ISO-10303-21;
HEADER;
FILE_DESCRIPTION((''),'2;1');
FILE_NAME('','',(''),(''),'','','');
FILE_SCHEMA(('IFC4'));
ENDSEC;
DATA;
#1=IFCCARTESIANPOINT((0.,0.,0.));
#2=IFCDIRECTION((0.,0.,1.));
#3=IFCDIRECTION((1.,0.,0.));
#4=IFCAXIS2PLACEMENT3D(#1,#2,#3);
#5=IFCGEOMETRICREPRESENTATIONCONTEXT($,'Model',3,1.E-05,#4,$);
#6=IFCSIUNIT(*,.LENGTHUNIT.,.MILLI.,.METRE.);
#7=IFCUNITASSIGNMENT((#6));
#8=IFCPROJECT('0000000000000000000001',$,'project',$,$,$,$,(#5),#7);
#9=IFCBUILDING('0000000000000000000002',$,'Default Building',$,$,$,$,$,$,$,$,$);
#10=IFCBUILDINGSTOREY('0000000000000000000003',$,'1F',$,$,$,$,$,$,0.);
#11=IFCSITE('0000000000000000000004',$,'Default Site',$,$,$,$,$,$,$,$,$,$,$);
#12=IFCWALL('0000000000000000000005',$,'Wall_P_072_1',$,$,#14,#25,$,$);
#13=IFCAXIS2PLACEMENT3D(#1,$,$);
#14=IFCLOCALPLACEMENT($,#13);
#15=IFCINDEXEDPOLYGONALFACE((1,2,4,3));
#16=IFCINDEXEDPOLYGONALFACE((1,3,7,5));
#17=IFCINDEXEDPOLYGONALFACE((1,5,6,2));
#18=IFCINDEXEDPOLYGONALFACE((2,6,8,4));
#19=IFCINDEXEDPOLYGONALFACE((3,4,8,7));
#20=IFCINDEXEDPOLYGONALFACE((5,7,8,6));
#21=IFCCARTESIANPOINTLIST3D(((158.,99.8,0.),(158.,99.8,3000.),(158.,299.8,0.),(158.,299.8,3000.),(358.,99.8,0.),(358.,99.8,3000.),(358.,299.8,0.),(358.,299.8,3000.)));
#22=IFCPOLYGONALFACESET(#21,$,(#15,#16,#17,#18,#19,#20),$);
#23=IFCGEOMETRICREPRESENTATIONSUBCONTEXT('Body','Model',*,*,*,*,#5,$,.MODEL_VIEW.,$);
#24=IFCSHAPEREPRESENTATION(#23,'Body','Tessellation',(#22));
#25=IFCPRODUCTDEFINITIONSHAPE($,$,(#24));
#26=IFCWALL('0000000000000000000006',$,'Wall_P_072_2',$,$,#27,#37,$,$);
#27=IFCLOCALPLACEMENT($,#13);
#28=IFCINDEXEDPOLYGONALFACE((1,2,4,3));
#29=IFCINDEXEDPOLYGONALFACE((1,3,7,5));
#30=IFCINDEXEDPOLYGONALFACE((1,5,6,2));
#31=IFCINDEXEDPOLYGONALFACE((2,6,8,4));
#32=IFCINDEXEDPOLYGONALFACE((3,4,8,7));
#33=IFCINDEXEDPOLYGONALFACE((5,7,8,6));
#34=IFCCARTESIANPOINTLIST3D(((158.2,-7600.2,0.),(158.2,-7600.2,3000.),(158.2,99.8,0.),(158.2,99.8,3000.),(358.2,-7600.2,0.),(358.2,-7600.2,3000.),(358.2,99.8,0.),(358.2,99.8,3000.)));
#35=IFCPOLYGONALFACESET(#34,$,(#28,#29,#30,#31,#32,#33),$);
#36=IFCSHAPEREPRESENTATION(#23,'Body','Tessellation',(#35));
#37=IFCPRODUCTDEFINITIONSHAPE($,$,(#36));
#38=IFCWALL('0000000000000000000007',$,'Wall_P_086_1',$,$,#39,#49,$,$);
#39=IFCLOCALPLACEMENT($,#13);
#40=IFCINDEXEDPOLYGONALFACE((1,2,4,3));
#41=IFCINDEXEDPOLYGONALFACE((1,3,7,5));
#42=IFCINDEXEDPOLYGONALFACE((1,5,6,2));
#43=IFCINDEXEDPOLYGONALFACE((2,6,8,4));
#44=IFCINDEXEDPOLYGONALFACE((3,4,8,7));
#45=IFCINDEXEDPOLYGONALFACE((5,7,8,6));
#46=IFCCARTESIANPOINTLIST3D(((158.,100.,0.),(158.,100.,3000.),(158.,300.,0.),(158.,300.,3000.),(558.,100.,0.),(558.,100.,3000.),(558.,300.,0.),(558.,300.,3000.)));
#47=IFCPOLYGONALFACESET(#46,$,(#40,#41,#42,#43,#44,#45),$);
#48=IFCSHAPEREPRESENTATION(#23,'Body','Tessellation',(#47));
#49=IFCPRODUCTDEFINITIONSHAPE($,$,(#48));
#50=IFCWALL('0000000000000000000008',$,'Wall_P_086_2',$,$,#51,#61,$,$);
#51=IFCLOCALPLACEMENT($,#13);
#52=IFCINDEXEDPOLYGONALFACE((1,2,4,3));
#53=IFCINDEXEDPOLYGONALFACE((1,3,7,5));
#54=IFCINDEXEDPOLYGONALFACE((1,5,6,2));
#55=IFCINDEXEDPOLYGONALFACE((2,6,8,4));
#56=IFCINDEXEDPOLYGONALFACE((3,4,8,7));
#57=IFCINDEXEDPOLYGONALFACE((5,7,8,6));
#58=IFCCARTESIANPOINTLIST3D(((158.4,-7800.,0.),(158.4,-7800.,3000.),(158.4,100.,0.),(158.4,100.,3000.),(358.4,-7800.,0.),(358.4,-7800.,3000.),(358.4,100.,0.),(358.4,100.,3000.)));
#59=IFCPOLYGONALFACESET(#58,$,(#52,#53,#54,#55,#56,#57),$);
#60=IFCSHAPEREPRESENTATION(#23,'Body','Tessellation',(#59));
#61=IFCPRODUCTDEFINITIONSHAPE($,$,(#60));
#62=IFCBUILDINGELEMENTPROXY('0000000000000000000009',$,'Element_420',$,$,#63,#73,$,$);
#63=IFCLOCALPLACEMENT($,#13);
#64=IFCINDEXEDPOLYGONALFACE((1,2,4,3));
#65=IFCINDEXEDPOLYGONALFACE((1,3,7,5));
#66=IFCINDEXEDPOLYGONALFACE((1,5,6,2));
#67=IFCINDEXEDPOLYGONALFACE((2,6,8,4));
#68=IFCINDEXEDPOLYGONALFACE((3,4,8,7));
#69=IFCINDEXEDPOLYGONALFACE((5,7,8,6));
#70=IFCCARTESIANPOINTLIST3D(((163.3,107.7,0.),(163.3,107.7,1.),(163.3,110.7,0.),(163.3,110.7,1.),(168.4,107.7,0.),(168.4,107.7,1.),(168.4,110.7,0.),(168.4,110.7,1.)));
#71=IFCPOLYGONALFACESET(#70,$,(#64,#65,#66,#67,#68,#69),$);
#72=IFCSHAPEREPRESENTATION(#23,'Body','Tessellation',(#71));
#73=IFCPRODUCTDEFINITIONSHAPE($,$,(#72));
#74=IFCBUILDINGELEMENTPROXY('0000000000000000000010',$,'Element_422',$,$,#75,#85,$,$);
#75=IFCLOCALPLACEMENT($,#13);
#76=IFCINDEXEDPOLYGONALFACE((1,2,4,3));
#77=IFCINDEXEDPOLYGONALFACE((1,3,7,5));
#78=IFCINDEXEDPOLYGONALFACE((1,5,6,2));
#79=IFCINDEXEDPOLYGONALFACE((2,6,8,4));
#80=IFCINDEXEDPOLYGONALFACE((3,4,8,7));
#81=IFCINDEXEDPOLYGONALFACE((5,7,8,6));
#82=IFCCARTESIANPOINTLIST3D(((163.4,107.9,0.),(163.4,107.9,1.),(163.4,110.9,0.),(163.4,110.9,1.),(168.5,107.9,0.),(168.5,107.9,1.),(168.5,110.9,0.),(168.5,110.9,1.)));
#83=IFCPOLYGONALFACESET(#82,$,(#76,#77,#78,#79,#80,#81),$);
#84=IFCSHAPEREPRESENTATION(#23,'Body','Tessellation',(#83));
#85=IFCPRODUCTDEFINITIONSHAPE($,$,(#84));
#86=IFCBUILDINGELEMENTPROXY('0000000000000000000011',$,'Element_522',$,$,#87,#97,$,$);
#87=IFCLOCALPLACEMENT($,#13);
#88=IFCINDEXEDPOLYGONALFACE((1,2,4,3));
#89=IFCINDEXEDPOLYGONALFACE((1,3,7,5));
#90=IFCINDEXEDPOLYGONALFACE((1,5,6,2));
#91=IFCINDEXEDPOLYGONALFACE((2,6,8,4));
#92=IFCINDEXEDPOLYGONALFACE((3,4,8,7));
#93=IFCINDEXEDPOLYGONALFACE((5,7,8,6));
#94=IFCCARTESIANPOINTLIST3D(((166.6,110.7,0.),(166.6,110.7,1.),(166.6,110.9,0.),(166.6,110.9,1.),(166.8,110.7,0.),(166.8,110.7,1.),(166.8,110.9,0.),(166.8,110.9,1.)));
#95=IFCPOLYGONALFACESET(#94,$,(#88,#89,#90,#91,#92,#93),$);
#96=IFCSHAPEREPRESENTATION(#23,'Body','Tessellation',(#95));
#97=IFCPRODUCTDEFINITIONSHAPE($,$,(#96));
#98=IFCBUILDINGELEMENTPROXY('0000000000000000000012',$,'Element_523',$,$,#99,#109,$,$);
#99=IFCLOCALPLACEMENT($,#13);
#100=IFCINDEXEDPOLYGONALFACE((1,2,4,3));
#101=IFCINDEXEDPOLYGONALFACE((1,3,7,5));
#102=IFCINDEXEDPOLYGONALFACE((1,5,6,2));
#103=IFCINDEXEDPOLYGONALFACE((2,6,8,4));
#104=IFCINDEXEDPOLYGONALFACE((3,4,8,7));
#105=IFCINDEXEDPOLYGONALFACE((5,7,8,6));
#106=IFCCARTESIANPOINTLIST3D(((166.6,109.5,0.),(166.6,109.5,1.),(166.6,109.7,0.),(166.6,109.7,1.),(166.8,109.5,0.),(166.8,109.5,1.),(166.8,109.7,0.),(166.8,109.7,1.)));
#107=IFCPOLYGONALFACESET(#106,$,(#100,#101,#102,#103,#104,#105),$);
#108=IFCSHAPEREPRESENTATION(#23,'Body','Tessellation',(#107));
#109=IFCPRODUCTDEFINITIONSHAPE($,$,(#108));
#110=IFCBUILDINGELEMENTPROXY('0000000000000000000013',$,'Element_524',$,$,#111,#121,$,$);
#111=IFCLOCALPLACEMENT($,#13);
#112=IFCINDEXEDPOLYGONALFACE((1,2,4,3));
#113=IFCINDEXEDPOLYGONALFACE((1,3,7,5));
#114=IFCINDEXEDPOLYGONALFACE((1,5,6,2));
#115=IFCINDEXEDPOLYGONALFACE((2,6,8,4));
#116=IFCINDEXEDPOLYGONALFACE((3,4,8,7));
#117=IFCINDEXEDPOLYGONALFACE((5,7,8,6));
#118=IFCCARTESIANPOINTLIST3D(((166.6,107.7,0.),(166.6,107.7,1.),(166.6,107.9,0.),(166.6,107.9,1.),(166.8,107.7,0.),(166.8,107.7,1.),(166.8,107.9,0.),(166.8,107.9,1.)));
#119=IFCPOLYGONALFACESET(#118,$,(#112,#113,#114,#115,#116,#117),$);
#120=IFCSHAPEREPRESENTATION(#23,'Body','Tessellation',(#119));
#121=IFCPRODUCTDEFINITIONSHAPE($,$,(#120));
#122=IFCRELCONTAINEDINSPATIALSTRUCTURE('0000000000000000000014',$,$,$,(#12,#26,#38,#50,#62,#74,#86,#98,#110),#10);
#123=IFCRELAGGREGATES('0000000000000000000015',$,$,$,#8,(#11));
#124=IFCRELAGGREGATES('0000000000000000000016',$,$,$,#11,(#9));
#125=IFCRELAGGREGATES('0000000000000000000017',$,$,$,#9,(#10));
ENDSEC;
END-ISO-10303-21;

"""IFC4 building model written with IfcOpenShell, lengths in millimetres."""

from ifc_helpers import new_model, si_unit, frame, origin, origin_with_axes, place, context, subcontext, project, spatial, polyline, indexed_curve, rectangle, outline, extrude, element, save


model = new_model("IFC4")

# Units and contexts
model_context = context("Model", 3, precision=1e-05, world=origin_with_axes())
body_context = subcontext(model_context, "Body", "Model", "MODEL_VIEW")
ifc_project = project(units=[si_unit("LENGTHUNIT", "METRE", prefix="MILLI")], contexts=[model_context])

# Site, building, storey
site = spatial("IfcSite", under=ifc_project, Name="Default Site")
building = spatial("IfcBuilding", under=site, Name="Default Building")
storey = spatial("IfcBuildingStorey", under=building, Name="1F", Elevation=0.0)

# Walls
wall_1_placement = place(None, frame((158.0, 99.8, 0.0), z_axis=(0.0, 0.0, 1.0), x_axis=(1.0, 0.0, 0.0)))
element("IfcWall", 1, at=wall_1_placement, inside=storey, Name="Wall_P_072_1", context=body_context, shape_type="SweptSolid", body=[
    extrude(outline(indexed_curve([(0.0, 0.0), (0.0, 200.0), (200.0, 200.0), (200.0, 0.0), (0.0, 0.0)], self_intersect=False)), origin_with_axes(), (0.0, 0.0, 1.0), 3000.0),
])
wall_2_placement = place(None, frame((158.2, 99.8, 0.0), z_axis=(0.0, 0.0, 1.0), x_axis=(0.0, -1.0, 0.0)))
element("IfcWall", 2, at=wall_2_placement, inside=storey, Name="Wall_P_072_2", context=body_context, shape_type="SweptSolid", body=[
    extrude(outline(indexed_curve([(0.0, 0.0), (0.0, 200.0), (7700.0, 200.0), (7700.0, 0.0), (0.0, 0.0)], self_intersect=False)), origin_with_axes(), (0.0, 0.0, 1.0), 3000.0),
])
wall_3_placement = place(None, frame((158.0, 100.0, 0.0), z_axis=(0.0, 0.0, 1.0), x_axis=(1.0, 0.0, 0.0)))
element("IfcWall", 3, at=wall_3_placement, inside=storey, Name="Wall_P_086_1", context=body_context, shape_type="SweptSolid", body=[
    extrude(outline(indexed_curve([(0.0, 0.0), (0.0, 200.0), (400.0, 200.0), (400.0, 0.0), (0.0, 0.0)], self_intersect=False)), origin_with_axes(), (0.0, 0.0, 1.0), 3000.0),
])
wall_4_placement = place(None, frame((158.4, 100.0, 0.0), z_axis=(0.0, 0.0, 1.0), x_axis=(0.0, -1.0, 0.0)))
element("IfcWall", 4, at=wall_4_placement, inside=storey, Name="Wall_P_086_2", context=body_context, shape_type="SweptSolid", body=[
    extrude(outline(indexed_curve([(0.0, 0.0), (0.0, 200.0), (7900.0, 200.0), (7900.0, 0.0), (0.0, 0.0)], self_intersect=False)), origin_with_axes(), (0.0, 0.0, 1.0), 3000.0),
])

# Building element proxies
proxy_1_placement = place(None, frame((165.9, 109.2, 0.0), z_axis=(0.0, 0.0, 1.0), x_axis=(1.0, 0.0, 0.0)))
element("IfcBuildingElementProxy", 5, at=proxy_1_placement, inside=storey, Name="Element_420", context=body_context, shape_type="SweptSolid", body=[
    extrude(rectangle(XDim=5.1, YDim=3.0), origin(), (0.0, 0.0, 1.0), 1.0),
])
proxy_2_placement = place(None, frame((166.0, 109.4, 0.0), z_axis=(0.0, 0.0, 1.0), x_axis=(1.0, 0.0, 0.0)))
element("IfcBuildingElementProxy", 6, at=proxy_2_placement, inside=storey, Name="Element_422", context=body_context, shape_type="SweptSolid", body=[
    extrude(rectangle(XDim=5.1, YDim=3.0), origin(), (0.0, 0.0, 1.0), 1.0),
])
proxy_3_placement = place(None, frame((166.7, 110.8, 0.0), z_axis=(0.0, 0.0, 1.0), x_axis=(1.0, 0.0, 0.0)))
element("IfcBuildingElementProxy", 7, at=proxy_3_placement, inside=storey, Name="Element_522", context=body_context, shape_type="SweptSolid", body=[
    extrude(outline(polyline([(-0.1, -0.1), (0.1, -0.1), (0.1, 0.1), (-0.1, 0.1), (-0.1, -0.1)])), origin(), (0.0, 0.0, 1.0), 1.0),
])
proxy_4_placement = place(None, frame((166.7, 109.6, 0.0), z_axis=(0.0, 0.0, 1.0), x_axis=(1.0, 0.0, 0.0)))
element("IfcBuildingElementProxy", 8, at=proxy_4_placement, inside=storey, Name="Element_523", context=body_context, shape_type="SweptSolid", body=[
    extrude(outline(polyline([(-0.1, -0.1), (0.1, -0.1), (0.1, 0.1), (-0.1, 0.1), (-0.1, -0.1)])), origin(), (0.0, 0.0, 1.0), 1.0),
])
proxy_5_placement = place(None, frame((166.7, 107.8, 0.0), z_axis=(0.0, 0.0, 1.0), x_axis=(1.0, 0.0, 0.0)))
element("IfcBuildingElementProxy", 9, at=proxy_5_placement, inside=storey, Name="Element_524", context=body_context, shape_type="SweptSolid", body=[
    extrude(outline(polyline([(-0.1, -0.1), (0.1, -0.1), (0.1, 0.1), (-0.1, 0.1), (-0.1, -0.1)])), origin(), (0.0, 0.0, 1.0), 1.0),
])

save(model, "model.ifc")
